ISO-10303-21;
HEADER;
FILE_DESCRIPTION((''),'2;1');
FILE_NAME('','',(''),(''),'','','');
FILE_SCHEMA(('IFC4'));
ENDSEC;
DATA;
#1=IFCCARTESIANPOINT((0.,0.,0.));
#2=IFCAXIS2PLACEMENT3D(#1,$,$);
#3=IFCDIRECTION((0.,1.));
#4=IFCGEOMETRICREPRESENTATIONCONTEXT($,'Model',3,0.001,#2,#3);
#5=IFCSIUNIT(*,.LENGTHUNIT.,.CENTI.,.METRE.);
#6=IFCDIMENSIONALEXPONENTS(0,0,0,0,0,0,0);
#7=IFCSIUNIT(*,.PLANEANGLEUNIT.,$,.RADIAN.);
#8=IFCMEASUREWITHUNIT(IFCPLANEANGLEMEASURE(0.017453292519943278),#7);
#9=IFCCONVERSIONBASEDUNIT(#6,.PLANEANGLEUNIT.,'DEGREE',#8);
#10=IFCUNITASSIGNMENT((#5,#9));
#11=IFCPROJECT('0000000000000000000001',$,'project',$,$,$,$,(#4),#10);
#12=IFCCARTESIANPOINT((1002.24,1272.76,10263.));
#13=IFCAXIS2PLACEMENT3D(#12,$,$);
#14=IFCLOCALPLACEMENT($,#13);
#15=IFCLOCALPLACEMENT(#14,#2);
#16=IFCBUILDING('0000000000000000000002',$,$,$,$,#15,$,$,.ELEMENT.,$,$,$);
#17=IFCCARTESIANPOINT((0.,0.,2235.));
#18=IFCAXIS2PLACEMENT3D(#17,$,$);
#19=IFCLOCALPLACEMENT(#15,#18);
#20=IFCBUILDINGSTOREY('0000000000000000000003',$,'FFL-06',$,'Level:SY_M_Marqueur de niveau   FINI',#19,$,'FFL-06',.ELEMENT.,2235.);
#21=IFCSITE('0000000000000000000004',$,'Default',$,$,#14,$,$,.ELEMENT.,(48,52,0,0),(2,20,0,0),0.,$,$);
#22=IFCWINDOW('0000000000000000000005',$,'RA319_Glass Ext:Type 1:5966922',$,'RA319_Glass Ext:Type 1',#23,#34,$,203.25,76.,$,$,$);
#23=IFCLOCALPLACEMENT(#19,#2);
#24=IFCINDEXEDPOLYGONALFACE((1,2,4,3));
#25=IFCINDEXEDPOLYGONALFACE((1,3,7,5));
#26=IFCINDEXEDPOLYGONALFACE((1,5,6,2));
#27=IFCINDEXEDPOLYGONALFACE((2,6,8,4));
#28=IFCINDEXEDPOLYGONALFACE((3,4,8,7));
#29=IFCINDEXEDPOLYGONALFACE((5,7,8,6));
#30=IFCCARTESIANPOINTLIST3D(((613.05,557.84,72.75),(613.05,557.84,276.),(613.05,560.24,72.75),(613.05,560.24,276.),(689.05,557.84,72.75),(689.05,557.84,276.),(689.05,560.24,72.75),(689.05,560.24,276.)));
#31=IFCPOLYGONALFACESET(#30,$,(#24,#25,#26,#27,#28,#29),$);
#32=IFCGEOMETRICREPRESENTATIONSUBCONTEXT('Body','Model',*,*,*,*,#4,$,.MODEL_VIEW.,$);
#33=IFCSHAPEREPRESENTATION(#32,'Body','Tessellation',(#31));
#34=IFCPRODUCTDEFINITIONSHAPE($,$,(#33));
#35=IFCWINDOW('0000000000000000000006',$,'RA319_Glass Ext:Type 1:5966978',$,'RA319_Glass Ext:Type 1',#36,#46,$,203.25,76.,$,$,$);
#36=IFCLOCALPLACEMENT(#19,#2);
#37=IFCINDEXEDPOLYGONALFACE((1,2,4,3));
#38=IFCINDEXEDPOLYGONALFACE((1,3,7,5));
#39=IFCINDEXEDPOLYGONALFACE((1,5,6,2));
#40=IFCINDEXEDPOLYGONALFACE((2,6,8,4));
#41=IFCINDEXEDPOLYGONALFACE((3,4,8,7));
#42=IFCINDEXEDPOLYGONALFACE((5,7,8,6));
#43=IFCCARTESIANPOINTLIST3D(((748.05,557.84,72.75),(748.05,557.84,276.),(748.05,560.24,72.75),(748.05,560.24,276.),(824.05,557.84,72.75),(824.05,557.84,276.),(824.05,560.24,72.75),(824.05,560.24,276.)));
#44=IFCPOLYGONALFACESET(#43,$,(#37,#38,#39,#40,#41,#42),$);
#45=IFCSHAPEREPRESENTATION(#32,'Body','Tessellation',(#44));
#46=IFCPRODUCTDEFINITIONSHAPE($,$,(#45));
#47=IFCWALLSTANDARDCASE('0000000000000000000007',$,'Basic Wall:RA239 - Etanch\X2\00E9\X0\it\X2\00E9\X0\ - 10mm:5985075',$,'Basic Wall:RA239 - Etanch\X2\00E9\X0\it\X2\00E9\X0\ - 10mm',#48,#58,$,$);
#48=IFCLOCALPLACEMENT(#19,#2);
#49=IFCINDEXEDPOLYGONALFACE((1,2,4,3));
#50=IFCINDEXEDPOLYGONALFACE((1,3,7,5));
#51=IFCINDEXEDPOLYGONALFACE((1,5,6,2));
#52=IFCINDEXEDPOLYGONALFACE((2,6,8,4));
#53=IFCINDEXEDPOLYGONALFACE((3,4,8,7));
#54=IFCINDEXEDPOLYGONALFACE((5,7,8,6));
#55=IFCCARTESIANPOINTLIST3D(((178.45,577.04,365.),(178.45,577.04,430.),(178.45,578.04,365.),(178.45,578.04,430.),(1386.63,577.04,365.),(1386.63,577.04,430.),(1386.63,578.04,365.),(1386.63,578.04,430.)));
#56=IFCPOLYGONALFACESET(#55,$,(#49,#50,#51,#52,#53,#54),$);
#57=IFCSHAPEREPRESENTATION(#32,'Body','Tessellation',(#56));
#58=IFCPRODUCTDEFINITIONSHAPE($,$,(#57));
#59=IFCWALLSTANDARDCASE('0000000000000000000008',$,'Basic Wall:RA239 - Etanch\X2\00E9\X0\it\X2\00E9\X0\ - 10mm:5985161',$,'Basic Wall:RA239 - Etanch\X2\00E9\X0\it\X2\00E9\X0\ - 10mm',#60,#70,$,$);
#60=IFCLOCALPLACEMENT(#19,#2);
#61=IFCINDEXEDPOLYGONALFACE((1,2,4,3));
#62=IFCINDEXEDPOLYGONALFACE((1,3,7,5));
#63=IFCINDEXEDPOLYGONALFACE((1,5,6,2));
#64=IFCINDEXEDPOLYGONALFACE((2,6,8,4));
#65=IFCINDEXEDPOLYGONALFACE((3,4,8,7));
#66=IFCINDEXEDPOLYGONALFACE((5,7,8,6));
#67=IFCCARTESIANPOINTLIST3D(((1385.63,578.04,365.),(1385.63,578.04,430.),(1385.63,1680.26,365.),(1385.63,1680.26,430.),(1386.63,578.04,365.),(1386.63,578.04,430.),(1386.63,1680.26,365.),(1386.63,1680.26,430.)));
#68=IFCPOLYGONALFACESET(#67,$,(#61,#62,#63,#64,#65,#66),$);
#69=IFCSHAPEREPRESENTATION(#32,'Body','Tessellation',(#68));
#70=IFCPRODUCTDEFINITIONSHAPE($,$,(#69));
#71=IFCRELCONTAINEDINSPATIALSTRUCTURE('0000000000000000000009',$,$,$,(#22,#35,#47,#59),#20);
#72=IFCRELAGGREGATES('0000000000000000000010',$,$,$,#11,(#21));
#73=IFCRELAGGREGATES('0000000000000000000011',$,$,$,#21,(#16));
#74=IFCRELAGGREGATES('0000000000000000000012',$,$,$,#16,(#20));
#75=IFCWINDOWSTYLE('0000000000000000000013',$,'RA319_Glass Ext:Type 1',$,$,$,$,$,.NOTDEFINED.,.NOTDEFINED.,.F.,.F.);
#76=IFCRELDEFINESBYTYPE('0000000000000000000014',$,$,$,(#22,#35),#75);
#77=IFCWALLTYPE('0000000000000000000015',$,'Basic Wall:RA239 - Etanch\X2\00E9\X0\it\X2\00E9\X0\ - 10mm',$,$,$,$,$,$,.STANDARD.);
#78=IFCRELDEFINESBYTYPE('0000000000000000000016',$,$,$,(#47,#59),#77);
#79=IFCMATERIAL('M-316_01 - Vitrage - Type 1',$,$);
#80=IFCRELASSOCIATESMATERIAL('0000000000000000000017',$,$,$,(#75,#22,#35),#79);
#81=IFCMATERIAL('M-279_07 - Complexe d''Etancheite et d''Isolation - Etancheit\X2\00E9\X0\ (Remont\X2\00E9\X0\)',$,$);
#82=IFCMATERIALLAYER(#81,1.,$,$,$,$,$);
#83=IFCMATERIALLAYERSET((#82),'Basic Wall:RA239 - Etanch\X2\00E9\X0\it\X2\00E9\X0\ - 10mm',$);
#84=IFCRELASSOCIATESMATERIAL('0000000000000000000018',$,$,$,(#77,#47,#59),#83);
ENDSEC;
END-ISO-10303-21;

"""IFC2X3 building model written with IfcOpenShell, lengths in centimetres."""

from ifc_helpers import new_model, entity, si_unit, converted_unit, direction, frame, frame_2d, origin, place, context, subcontext, project, spatial, polyline, rectangle, extrude, clip, bounded_halfspace, source, transform, mapped, material, layer, layer_set, layer_usage, type_object, type_shapes, element, save


model = new_model("IFC2X3")

# Units and contexts
model_context = context("Model", 3, precision=0.001, world=origin(), true_north=direction((0.0, 1.0)))
body_context = subcontext(model_context, "Body", "Model", "MODEL_VIEW")
ifc_project = project(units=[si_unit("LENGTHUNIT", "METRE", prefix="CENTI"), converted_unit("PLANEANGLEUNIT", "DEGREE", entity("IfcPlaneAngleMeasure", 0.017453292519943278), si_unit("PLANEANGLEUNIT", "RADIAN"), dimensions=[0, 0, 0, 0, 0, 0, 0])], contexts=[model_context])

# Site, building, storey
site_placement = place(None, frame((1002.24, 1272.76, 10263.0)))
site = spatial("IfcSite", under=ifc_project, at=site_placement, Name="Default", CompositionType="ELEMENT", RefLatitude=(48, 52, 0, 0), RefLongitude=(2, 20, 0, 0), RefElevation=0.0)
building_placement = place(site_placement, origin())
building = spatial("IfcBuilding", under=site, at=building_placement, CompositionType="ELEMENT")
storey_placement = place(building_placement, frame((0.0, 0.0, 2235.0)))
storey = spatial("IfcBuildingStorey", under=building, at=storey_placement, Name="FFL-06", ObjectType="Level:SY_M_Marqueur de niveau   FINI", LongName="FFL-06", CompositionType="ELEMENT", Elevation=2235.0)

# Windows
ifc_material_1 = material(Name="M-316_01 - Vitrage - Type 1")
window_style_1 = type_object("IfcWindowStyle", Name="RA319_Glass Ext:Type 1", ConstructionType="NOTDEFINED", OperationType="NOTDEFINED", ParameterTakesPrecedence=False, Sizeable=False, material=ifc_material_1)
shared_shape_1 = source(origin(), body_context, "Body", "SweptSolid", [
    extrude(rectangle(XDim=76.0, YDim=203.25, at=frame_2d((0.0, 0.0), x_axis=(1.0, 0.0))), frame((0.0, 0.0, 0.0), z_axis=(0.0, 0.0, 1.0), x_axis=(-1.0, 0.0, 0.0)), (0.0, 0.0, 1.0), 2.4),
])
type_shapes(window_style_1, [shared_shape_1])
for number, where, z_axis, x_axis, name in (
    (1, (651.05, 557.84, 174.37), (0.0, 1.0, 0.0), (-1.0, 0.0, 0.0), "RA319_Glass Ext:Type 1:5966922"),
    (2, (786.05, 557.84, 174.37), (0.0, 1.0, 0.0), (-1.0, 0.0, 0.0), "RA319_Glass Ext:Type 1:5966978"),
):
    element("IfcWindow", number, at=place(storey_placement, frame(where, z_axis=z_axis, x_axis=x_axis)), inside=storey, type_object=window_style_1, material=ifc_material_1, Name=name, ObjectType="RA319_Glass Ext:Type 1", OverallHeight=203.25, OverallWidth=76.0, context=body_context, shape_type="MappedRepresentation", body=[
        mapped(shared_shape_1, transform((0.0, 0.0, 0.0), scale=1.0)),
    ])

# Walls
ifc_material_2 = material(Name="M-279_07 - Complexe d'Etancheite et d'Isolation - Etancheité (Remonté)")
ifc_layer_1 = layer(ifc_material_2, 1.0)
ifc_layer_set_1 = layer_set([ifc_layer_1], Name="Basic Wall:RA239 - Etanchéité - 10mm")
ifc_layer_usage_1 = layer_usage(ifc_layer_set_1, "AXIS2", "NEGATIVE", 0.5)
wall_type_1 = type_object("IfcWallType", Name="Basic Wall:RA239 - Etanchéité - 10mm", PredefinedType="STANDARD", material=ifc_layer_set_1)
wall_1_placement = place(storey_placement, frame((1386.63, 577.54, 365.0), z_axis=(0.0, 0.0, 1.0), x_axis=(-1.0, 0.0, 0.0)))
element("IfcWallStandardCase", 3, at=wall_1_placement, inside=storey, type_object=wall_type_1, material=ifc_layer_usage_1, Name="Basic Wall:RA239 - Etanchéité - 10mm:5985075", ObjectType="Basic Wall:RA239 - Etanchéité - 10mm", context=body_context, shape_type="Clipping", body=[
    clip(extrude(rectangle(XDim=1208.19, YDim=1.0, at=frame_2d((604.09, 0.0), x_axis=(-1.0, 0.0))), origin(), (0.0, 0.0, 1.0), 65.0), bounded_halfspace(frame((1208.19, -0.5, 0.0), z_axis=(0.0, 0.0, 1.0), x_axis=(-1.0, 0.0, 0.0)), True, frame((1208.19, -0.5, 0.0)), polyline([(0.0, 0.0), (0.0, 1.0), (-1208.19, 1.0), (-1208.19, 0.0), (-1207.19, 0.0), (-1.0, 0.0), (0.0, 0.0)]))),
])
ifc_layer_usage_2 = layer_usage(ifc_layer_set_1, "AXIS2", "POSITIVE", -0.5)
wall_2_placement = place(storey_placement, frame((1386.13, 578.04, 365.0), z_axis=(0.0, 0.0, 1.0), x_axis=(0.0, 1.0, 0.0)))
element("IfcWallStandardCase", 4, at=wall_2_placement, inside=storey, type_object=wall_type_1, material=ifc_layer_usage_2, Name="Basic Wall:RA239 - Etanchéité - 10mm:5985161", ObjectType="Basic Wall:RA239 - Etanchéité - 10mm", context=body_context, shape_type="Clipping", body=[
    clip(extrude(rectangle(XDim=1102.22, YDim=1.0, at=frame_2d((551.11, 0.0), x_axis=(-1.0, 0.0))), origin(), (0.0, 0.0, 1.0), 65.0), bounded_halfspace(frame((1102.22, -0.5, 0.0), z_axis=(0.0, 0.0, 1.0), x_axis=(0.0, -1.0, 0.0)), True, frame((1102.22, -0.5, 0.0), z_axis=(0.0, 0.0, 1.0), x_axis=(0.0, -1.0, 0.0)), polyline([(0.0, 0.0), (-1.0, 0.0), (-1.0, -1102.22), (0.0, -1102.22), (0.0, 0.0)]))),
])

save(model, "model.ifc")
